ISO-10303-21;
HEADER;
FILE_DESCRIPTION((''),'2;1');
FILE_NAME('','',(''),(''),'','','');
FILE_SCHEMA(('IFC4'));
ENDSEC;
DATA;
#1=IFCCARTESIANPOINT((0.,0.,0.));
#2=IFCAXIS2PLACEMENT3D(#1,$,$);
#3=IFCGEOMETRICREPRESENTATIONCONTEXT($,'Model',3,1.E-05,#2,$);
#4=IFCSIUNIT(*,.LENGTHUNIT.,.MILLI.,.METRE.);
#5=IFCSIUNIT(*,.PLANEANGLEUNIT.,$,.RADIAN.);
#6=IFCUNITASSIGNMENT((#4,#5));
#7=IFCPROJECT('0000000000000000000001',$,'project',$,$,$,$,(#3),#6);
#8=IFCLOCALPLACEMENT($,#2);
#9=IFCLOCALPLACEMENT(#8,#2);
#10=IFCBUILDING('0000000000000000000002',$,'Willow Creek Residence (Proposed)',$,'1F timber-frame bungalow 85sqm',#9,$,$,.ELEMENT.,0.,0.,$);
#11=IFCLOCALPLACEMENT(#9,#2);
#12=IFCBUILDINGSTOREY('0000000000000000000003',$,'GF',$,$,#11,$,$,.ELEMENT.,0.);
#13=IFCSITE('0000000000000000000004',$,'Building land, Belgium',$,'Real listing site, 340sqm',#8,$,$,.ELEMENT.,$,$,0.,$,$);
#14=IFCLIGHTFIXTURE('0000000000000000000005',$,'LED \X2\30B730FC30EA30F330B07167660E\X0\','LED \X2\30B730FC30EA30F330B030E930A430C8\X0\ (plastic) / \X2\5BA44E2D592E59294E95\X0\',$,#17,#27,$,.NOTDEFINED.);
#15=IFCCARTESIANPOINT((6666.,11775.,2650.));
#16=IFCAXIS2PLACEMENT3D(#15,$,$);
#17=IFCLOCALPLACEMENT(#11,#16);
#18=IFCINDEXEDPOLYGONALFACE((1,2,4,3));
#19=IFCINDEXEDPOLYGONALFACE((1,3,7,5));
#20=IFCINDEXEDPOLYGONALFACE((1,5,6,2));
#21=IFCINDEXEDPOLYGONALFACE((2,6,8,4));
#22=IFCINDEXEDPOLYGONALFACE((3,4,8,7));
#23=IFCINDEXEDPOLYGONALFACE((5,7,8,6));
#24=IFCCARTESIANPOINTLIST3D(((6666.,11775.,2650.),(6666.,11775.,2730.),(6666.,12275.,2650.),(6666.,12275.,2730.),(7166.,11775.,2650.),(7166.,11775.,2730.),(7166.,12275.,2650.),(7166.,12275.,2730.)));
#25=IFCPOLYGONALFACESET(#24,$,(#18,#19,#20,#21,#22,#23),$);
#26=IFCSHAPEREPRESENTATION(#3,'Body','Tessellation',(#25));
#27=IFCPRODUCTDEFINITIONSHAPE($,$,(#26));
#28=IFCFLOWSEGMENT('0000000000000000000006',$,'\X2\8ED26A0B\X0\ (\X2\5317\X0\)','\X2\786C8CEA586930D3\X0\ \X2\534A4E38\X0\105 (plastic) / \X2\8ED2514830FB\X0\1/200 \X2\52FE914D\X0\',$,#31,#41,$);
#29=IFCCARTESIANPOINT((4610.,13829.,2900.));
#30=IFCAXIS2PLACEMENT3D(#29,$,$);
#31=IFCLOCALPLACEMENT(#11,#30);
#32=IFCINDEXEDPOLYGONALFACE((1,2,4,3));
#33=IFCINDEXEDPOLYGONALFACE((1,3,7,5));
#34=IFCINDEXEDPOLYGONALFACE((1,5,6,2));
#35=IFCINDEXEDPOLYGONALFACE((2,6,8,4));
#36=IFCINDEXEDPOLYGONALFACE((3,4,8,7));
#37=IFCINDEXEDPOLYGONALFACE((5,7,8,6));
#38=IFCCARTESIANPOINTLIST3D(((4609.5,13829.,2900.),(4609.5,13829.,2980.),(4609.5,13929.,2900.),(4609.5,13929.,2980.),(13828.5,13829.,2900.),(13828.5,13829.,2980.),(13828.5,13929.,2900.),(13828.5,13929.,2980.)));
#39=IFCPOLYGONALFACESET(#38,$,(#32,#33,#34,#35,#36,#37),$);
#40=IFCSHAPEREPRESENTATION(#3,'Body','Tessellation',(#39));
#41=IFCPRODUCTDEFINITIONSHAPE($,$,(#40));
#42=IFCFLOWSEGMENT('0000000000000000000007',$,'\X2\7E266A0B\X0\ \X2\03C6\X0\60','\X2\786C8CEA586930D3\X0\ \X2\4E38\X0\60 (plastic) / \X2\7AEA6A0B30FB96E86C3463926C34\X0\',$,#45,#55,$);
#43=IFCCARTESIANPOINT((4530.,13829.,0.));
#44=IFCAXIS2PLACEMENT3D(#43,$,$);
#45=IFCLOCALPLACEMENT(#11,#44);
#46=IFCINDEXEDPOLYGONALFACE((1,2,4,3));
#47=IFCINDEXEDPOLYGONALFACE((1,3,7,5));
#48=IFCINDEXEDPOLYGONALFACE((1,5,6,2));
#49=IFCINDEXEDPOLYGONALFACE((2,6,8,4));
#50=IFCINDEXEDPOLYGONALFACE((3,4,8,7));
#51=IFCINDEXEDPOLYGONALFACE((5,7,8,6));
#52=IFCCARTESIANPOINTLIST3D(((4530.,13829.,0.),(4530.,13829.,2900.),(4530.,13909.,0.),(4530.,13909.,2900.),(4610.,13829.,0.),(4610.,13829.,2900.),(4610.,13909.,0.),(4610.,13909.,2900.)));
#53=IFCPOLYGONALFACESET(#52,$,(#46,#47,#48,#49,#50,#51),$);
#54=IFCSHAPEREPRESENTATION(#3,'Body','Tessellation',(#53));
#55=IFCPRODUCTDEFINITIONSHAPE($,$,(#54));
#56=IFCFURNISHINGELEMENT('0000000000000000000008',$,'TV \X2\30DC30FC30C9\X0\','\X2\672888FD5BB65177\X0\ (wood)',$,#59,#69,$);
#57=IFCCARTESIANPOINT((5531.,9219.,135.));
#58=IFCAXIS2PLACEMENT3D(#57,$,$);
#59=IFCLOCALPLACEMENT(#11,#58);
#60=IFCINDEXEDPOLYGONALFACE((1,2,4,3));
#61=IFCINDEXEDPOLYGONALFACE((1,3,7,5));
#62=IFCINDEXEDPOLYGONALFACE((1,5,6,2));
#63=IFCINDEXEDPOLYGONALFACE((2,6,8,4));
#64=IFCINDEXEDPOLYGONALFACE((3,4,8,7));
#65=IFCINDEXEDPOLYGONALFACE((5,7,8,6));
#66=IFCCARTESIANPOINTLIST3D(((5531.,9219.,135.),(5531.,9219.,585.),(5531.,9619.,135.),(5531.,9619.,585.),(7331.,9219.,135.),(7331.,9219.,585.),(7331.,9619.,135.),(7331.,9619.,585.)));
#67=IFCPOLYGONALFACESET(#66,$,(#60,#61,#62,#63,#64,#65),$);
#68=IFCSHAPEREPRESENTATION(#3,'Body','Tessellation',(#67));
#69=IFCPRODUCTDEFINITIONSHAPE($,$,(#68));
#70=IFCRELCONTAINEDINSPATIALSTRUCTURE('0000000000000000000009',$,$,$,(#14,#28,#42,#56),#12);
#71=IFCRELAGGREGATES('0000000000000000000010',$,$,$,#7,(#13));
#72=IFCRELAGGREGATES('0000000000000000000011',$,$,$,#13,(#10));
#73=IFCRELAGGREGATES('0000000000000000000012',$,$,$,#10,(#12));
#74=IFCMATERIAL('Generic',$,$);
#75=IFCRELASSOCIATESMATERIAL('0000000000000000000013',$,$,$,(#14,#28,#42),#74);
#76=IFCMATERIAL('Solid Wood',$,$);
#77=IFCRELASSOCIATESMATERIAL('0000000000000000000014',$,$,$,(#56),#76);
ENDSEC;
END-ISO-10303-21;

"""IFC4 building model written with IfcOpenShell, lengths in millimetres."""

from ifc_helpers import new_model, si_unit, frame, frame_2d, origin, place, context, project, spatial, rectangle, extrude, material, element, save


model = new_model("IFC4")

# Units and contexts
model_context = context("Model", 3, precision=1e-05, world=origin())
ifc_project = project(units=[si_unit("LENGTHUNIT", "METRE", prefix="MILLI"), si_unit("PLANEANGLEUNIT", "RADIAN")], contexts=[model_context])

# Site, building, storey
site_placement = place(None, origin())
site = spatial("IfcSite", under=ifc_project, at=site_placement, Name="Building land, Belgium", ObjectType="Real listing site, 340sqm", CompositionType="ELEMENT", RefElevation=0.0)
building_placement = place(site_placement, origin())
building = spatial("IfcBuilding", under=site, at=building_placement, Name="Willow Creek Residence (Proposed)", ObjectType="1F timber-frame bungalow 85sqm", CompositionType="ELEMENT", ElevationOfRefHeight=0.0, ElevationOfTerrain=0.0)
storey_placement = place(building_placement, origin())
storey = spatial("IfcBuildingStorey", under=building, at=storey_placement, Name="GF", CompositionType="ELEMENT", Elevation=0.0)

# Shared definitions
ifc_material_1 = material(Name="Solid Wood")

# Shared definitions
ifc_material_2 = material(Name="Generic")

# Light fixture
light_fixture_placement = place(storey_placement, frame((6666.0, 11775.0, 2650.0)))
element("IfcLightFixture", 1, at=light_fixture_placement, inside=storey, material=ifc_material_2, Name="LED シーリング照明", Description="LED シーリングライト (plastic) / 室中央天井", PredefinedType="NOTDEFINED", context=model_context, shape_type="SweptSolid", body=[
    extrude(rectangle(XDim=500.0, YDim=500.0, at=frame_2d((250.0, 250.0))), frame((6666.0, 11775.0, 2650.0)), (0.0, 0.0, 1.0), 80.0),
])

# Flow segments
flow_segment_1_placement = place(storey_placement, frame((4610.0, 13829.0, 2900.0)))
element("IfcFlowSegment", 2, at=flow_segment_1_placement, inside=storey, material=ifc_material_2, Name="軒樋 (北)", Description="硬質塩ビ 半丸105 (plastic) / 軒先・1/200 勾配", context=model_context, shape_type="SweptSolid", body=[
    extrude(rectangle(XDim=9219.0, YDim=100.0, at=frame_2d((4609.0, 50.0))), frame((4610.0, 13829.0, 2900.0)), (0.0, 0.0, 1.0), 80.0),
])
flow_segment_2_placement = place(storey_placement, frame((4530.0, 13829.0, 0.0)))
element("IfcFlowSegment", 3, at=flow_segment_2_placement, inside=storey, material=ifc_material_2, Name="縦樋 φ60", Description="硬質塩ビ 丸60 (plastic) / 竪樋・雨水排水", context=model_context, shape_type="SweptSolid", body=[
    extrude(rectangle(XDim=80.0, YDim=80.0, at=frame_2d((40.0, 40.0))), frame((4530.0, 13829.0, 0.0)), (0.0, 0.0, 1.0), 2900.0),
])

# Furnishing element
furnishing_placement = place(storey_placement, frame((5531.0, 9219.0, 135.0)))
element("IfcFurnishingElement", 4, at=furnishing_placement, inside=storey, material=ifc_material_1, Name="TV ボード", Description="木製家具 (wood)", context=model_context, shape_type="SweptSolid", body=[
    extrude(rectangle(XDim=1800.0, YDim=400.0, at=frame_2d((900.0, 200.0))), frame((5531.0, 9219.0, 135.0)), (0.0, 0.0, 1.0), 450.0),
])

save(model, "model.ifc")
